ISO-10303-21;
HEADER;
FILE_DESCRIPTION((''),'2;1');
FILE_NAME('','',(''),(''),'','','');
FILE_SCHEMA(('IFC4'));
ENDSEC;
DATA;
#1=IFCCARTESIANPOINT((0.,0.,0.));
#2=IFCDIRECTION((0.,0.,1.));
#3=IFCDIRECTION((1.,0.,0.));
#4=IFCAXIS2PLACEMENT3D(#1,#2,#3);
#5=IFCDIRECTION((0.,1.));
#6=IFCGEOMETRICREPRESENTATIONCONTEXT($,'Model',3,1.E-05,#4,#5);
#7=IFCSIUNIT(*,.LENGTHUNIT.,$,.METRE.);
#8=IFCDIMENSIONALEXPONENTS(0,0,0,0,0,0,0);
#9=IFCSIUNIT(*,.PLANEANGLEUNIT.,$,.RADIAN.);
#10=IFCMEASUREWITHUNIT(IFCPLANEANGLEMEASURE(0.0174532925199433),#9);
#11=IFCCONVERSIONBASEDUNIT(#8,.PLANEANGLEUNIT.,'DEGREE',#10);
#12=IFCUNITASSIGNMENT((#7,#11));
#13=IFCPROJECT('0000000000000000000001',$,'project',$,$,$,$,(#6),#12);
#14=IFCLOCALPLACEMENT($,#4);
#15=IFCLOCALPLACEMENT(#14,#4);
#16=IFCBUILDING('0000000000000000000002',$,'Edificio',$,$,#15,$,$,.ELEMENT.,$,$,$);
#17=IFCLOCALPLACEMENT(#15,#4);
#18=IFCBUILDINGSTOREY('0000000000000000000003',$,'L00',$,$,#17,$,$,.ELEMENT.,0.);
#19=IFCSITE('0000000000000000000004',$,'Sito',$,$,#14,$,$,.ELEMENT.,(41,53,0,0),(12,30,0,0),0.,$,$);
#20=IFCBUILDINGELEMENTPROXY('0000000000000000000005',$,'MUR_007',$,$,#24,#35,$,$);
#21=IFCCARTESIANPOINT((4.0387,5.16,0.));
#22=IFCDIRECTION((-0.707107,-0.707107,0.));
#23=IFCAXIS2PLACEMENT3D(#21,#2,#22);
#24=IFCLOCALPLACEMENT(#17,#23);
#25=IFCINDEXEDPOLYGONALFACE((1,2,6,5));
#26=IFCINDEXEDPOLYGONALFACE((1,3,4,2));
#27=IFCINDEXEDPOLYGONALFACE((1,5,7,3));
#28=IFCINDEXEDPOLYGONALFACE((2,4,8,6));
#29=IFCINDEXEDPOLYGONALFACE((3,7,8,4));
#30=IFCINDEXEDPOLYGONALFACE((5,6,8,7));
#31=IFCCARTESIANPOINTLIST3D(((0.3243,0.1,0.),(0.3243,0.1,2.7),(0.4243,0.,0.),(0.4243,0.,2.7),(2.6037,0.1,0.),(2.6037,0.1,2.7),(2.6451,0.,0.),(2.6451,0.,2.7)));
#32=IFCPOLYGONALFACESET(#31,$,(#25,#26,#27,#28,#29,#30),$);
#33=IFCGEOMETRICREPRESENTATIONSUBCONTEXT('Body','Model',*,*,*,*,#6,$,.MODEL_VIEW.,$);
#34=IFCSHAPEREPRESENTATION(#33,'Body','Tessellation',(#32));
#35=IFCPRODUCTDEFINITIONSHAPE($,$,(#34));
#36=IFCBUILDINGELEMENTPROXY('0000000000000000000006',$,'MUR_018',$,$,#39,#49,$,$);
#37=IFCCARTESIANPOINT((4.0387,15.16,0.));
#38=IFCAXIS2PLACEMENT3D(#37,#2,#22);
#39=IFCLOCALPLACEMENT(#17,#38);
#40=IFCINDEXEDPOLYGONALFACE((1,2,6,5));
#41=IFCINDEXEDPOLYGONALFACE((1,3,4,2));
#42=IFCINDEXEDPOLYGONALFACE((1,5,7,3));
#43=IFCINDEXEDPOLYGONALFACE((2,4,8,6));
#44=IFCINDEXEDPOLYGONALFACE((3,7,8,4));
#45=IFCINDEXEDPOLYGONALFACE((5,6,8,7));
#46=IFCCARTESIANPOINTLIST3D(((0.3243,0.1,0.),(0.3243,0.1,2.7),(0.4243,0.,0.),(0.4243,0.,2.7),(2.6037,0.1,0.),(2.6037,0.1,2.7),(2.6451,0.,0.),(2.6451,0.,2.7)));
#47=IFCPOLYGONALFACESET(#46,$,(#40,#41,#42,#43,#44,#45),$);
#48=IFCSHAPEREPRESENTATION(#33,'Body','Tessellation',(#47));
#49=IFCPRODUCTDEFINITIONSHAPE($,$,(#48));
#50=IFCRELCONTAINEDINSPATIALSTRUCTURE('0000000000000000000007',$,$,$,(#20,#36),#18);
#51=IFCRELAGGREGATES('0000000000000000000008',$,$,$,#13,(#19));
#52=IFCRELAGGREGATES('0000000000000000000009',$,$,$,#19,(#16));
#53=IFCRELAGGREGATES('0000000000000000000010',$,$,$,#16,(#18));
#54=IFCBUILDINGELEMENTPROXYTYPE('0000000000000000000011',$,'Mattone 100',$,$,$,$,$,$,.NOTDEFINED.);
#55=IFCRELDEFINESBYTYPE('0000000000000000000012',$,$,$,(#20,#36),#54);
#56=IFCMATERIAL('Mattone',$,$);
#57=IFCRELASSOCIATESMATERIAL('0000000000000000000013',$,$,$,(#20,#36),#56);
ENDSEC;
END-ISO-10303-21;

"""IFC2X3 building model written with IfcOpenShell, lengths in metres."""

from ifc_helpers import new_model, entity, si_unit, converted_unit, direction, frame, origin_with_axes, place, context, subcontext, project, spatial, polyline, outline, extrude, material, type_object, element, save


model = new_model("IFC2X3")

# Units and contexts
model_context = context("Model", 3, precision=1e-05, world=origin_with_axes(), true_north=direction((0.0, 1.0)))
body_context = subcontext(model_context, "Body", "Model", "MODEL_VIEW")
ifc_project = project(units=[si_unit("LENGTHUNIT", "METRE"), converted_unit("PLANEANGLEUNIT", "DEGREE", entity("IfcPlaneAngleMeasure", 0.0174532925199433), si_unit("PLANEANGLEUNIT", "RADIAN"), dimensions=[0, 0, 0, 0, 0, 0, 0])], contexts=[model_context])

# Site, building, storey
site_placement = place(None, origin_with_axes())
site = spatial("IfcSite", under=ifc_project, at=site_placement, Name="Sito", CompositionType="ELEMENT", RefLatitude=(41, 53, 0, 0), RefLongitude=(12, 30, 0, 0), RefElevation=0.0)
building_placement = place(site_placement, origin_with_axes())
building = spatial("IfcBuilding", under=site, at=building_placement, Name="Edificio", CompositionType="ELEMENT")
storey_placement = place(building_placement, origin_with_axes())
storey = spatial("IfcBuildingStorey", under=building, at=storey_placement, Name="L00", CompositionType="ELEMENT", Elevation=0.0)

# Building element proxies
ifc_material_1 = material(Name="Mattone")
building_element_proxy_type_1 = type_object("IfcBuildingElementProxyType", Name="Mattone 100", PredefinedType="NOTDEFINED")
proxy_1_placement = place(storey_placement, frame((4.0387, 5.16, 0.0), z_axis=(0.0, 0.0, 1.0), x_axis=(-0.707107, -0.707107, 0.0)))
element("IfcBuildingElementProxy", 1, at=proxy_1_placement, inside=storey, type_object=building_element_proxy_type_1, material=ifc_material_1, Name="MUR_007", context=body_context, shape_type="SweptSolid", body=[
    extrude(outline(polyline([(0.4243, 0.0), (2.6451, 0.0), (2.6037, 0.1), (0.3243, 0.1), (0.4243, 0.0)])), origin_with_axes(), (0.0, 0.0, 1.0), 2.7),
])
proxy_2_placement = place(storey_placement, frame((4.0387, 15.16, 0.0), z_axis=(0.0, 0.0, 1.0), x_axis=(-0.707107, -0.707107, 0.0)))
element("IfcBuildingElementProxy", 2, at=proxy_2_placement, inside=storey, type_object=building_element_proxy_type_1, material=ifc_material_1, Name="MUR_018", context=body_context, shape_type="SweptSolid", body=[
    extrude(outline(polyline([(0.4243, 0.0), (2.6451, 0.0), (2.6037, 0.1), (0.3243, 0.1), (0.4243, 0.0)])), origin_with_axes(), (0.0, 0.0, 1.0), 2.7),
])

save(model, "model.ifc")
